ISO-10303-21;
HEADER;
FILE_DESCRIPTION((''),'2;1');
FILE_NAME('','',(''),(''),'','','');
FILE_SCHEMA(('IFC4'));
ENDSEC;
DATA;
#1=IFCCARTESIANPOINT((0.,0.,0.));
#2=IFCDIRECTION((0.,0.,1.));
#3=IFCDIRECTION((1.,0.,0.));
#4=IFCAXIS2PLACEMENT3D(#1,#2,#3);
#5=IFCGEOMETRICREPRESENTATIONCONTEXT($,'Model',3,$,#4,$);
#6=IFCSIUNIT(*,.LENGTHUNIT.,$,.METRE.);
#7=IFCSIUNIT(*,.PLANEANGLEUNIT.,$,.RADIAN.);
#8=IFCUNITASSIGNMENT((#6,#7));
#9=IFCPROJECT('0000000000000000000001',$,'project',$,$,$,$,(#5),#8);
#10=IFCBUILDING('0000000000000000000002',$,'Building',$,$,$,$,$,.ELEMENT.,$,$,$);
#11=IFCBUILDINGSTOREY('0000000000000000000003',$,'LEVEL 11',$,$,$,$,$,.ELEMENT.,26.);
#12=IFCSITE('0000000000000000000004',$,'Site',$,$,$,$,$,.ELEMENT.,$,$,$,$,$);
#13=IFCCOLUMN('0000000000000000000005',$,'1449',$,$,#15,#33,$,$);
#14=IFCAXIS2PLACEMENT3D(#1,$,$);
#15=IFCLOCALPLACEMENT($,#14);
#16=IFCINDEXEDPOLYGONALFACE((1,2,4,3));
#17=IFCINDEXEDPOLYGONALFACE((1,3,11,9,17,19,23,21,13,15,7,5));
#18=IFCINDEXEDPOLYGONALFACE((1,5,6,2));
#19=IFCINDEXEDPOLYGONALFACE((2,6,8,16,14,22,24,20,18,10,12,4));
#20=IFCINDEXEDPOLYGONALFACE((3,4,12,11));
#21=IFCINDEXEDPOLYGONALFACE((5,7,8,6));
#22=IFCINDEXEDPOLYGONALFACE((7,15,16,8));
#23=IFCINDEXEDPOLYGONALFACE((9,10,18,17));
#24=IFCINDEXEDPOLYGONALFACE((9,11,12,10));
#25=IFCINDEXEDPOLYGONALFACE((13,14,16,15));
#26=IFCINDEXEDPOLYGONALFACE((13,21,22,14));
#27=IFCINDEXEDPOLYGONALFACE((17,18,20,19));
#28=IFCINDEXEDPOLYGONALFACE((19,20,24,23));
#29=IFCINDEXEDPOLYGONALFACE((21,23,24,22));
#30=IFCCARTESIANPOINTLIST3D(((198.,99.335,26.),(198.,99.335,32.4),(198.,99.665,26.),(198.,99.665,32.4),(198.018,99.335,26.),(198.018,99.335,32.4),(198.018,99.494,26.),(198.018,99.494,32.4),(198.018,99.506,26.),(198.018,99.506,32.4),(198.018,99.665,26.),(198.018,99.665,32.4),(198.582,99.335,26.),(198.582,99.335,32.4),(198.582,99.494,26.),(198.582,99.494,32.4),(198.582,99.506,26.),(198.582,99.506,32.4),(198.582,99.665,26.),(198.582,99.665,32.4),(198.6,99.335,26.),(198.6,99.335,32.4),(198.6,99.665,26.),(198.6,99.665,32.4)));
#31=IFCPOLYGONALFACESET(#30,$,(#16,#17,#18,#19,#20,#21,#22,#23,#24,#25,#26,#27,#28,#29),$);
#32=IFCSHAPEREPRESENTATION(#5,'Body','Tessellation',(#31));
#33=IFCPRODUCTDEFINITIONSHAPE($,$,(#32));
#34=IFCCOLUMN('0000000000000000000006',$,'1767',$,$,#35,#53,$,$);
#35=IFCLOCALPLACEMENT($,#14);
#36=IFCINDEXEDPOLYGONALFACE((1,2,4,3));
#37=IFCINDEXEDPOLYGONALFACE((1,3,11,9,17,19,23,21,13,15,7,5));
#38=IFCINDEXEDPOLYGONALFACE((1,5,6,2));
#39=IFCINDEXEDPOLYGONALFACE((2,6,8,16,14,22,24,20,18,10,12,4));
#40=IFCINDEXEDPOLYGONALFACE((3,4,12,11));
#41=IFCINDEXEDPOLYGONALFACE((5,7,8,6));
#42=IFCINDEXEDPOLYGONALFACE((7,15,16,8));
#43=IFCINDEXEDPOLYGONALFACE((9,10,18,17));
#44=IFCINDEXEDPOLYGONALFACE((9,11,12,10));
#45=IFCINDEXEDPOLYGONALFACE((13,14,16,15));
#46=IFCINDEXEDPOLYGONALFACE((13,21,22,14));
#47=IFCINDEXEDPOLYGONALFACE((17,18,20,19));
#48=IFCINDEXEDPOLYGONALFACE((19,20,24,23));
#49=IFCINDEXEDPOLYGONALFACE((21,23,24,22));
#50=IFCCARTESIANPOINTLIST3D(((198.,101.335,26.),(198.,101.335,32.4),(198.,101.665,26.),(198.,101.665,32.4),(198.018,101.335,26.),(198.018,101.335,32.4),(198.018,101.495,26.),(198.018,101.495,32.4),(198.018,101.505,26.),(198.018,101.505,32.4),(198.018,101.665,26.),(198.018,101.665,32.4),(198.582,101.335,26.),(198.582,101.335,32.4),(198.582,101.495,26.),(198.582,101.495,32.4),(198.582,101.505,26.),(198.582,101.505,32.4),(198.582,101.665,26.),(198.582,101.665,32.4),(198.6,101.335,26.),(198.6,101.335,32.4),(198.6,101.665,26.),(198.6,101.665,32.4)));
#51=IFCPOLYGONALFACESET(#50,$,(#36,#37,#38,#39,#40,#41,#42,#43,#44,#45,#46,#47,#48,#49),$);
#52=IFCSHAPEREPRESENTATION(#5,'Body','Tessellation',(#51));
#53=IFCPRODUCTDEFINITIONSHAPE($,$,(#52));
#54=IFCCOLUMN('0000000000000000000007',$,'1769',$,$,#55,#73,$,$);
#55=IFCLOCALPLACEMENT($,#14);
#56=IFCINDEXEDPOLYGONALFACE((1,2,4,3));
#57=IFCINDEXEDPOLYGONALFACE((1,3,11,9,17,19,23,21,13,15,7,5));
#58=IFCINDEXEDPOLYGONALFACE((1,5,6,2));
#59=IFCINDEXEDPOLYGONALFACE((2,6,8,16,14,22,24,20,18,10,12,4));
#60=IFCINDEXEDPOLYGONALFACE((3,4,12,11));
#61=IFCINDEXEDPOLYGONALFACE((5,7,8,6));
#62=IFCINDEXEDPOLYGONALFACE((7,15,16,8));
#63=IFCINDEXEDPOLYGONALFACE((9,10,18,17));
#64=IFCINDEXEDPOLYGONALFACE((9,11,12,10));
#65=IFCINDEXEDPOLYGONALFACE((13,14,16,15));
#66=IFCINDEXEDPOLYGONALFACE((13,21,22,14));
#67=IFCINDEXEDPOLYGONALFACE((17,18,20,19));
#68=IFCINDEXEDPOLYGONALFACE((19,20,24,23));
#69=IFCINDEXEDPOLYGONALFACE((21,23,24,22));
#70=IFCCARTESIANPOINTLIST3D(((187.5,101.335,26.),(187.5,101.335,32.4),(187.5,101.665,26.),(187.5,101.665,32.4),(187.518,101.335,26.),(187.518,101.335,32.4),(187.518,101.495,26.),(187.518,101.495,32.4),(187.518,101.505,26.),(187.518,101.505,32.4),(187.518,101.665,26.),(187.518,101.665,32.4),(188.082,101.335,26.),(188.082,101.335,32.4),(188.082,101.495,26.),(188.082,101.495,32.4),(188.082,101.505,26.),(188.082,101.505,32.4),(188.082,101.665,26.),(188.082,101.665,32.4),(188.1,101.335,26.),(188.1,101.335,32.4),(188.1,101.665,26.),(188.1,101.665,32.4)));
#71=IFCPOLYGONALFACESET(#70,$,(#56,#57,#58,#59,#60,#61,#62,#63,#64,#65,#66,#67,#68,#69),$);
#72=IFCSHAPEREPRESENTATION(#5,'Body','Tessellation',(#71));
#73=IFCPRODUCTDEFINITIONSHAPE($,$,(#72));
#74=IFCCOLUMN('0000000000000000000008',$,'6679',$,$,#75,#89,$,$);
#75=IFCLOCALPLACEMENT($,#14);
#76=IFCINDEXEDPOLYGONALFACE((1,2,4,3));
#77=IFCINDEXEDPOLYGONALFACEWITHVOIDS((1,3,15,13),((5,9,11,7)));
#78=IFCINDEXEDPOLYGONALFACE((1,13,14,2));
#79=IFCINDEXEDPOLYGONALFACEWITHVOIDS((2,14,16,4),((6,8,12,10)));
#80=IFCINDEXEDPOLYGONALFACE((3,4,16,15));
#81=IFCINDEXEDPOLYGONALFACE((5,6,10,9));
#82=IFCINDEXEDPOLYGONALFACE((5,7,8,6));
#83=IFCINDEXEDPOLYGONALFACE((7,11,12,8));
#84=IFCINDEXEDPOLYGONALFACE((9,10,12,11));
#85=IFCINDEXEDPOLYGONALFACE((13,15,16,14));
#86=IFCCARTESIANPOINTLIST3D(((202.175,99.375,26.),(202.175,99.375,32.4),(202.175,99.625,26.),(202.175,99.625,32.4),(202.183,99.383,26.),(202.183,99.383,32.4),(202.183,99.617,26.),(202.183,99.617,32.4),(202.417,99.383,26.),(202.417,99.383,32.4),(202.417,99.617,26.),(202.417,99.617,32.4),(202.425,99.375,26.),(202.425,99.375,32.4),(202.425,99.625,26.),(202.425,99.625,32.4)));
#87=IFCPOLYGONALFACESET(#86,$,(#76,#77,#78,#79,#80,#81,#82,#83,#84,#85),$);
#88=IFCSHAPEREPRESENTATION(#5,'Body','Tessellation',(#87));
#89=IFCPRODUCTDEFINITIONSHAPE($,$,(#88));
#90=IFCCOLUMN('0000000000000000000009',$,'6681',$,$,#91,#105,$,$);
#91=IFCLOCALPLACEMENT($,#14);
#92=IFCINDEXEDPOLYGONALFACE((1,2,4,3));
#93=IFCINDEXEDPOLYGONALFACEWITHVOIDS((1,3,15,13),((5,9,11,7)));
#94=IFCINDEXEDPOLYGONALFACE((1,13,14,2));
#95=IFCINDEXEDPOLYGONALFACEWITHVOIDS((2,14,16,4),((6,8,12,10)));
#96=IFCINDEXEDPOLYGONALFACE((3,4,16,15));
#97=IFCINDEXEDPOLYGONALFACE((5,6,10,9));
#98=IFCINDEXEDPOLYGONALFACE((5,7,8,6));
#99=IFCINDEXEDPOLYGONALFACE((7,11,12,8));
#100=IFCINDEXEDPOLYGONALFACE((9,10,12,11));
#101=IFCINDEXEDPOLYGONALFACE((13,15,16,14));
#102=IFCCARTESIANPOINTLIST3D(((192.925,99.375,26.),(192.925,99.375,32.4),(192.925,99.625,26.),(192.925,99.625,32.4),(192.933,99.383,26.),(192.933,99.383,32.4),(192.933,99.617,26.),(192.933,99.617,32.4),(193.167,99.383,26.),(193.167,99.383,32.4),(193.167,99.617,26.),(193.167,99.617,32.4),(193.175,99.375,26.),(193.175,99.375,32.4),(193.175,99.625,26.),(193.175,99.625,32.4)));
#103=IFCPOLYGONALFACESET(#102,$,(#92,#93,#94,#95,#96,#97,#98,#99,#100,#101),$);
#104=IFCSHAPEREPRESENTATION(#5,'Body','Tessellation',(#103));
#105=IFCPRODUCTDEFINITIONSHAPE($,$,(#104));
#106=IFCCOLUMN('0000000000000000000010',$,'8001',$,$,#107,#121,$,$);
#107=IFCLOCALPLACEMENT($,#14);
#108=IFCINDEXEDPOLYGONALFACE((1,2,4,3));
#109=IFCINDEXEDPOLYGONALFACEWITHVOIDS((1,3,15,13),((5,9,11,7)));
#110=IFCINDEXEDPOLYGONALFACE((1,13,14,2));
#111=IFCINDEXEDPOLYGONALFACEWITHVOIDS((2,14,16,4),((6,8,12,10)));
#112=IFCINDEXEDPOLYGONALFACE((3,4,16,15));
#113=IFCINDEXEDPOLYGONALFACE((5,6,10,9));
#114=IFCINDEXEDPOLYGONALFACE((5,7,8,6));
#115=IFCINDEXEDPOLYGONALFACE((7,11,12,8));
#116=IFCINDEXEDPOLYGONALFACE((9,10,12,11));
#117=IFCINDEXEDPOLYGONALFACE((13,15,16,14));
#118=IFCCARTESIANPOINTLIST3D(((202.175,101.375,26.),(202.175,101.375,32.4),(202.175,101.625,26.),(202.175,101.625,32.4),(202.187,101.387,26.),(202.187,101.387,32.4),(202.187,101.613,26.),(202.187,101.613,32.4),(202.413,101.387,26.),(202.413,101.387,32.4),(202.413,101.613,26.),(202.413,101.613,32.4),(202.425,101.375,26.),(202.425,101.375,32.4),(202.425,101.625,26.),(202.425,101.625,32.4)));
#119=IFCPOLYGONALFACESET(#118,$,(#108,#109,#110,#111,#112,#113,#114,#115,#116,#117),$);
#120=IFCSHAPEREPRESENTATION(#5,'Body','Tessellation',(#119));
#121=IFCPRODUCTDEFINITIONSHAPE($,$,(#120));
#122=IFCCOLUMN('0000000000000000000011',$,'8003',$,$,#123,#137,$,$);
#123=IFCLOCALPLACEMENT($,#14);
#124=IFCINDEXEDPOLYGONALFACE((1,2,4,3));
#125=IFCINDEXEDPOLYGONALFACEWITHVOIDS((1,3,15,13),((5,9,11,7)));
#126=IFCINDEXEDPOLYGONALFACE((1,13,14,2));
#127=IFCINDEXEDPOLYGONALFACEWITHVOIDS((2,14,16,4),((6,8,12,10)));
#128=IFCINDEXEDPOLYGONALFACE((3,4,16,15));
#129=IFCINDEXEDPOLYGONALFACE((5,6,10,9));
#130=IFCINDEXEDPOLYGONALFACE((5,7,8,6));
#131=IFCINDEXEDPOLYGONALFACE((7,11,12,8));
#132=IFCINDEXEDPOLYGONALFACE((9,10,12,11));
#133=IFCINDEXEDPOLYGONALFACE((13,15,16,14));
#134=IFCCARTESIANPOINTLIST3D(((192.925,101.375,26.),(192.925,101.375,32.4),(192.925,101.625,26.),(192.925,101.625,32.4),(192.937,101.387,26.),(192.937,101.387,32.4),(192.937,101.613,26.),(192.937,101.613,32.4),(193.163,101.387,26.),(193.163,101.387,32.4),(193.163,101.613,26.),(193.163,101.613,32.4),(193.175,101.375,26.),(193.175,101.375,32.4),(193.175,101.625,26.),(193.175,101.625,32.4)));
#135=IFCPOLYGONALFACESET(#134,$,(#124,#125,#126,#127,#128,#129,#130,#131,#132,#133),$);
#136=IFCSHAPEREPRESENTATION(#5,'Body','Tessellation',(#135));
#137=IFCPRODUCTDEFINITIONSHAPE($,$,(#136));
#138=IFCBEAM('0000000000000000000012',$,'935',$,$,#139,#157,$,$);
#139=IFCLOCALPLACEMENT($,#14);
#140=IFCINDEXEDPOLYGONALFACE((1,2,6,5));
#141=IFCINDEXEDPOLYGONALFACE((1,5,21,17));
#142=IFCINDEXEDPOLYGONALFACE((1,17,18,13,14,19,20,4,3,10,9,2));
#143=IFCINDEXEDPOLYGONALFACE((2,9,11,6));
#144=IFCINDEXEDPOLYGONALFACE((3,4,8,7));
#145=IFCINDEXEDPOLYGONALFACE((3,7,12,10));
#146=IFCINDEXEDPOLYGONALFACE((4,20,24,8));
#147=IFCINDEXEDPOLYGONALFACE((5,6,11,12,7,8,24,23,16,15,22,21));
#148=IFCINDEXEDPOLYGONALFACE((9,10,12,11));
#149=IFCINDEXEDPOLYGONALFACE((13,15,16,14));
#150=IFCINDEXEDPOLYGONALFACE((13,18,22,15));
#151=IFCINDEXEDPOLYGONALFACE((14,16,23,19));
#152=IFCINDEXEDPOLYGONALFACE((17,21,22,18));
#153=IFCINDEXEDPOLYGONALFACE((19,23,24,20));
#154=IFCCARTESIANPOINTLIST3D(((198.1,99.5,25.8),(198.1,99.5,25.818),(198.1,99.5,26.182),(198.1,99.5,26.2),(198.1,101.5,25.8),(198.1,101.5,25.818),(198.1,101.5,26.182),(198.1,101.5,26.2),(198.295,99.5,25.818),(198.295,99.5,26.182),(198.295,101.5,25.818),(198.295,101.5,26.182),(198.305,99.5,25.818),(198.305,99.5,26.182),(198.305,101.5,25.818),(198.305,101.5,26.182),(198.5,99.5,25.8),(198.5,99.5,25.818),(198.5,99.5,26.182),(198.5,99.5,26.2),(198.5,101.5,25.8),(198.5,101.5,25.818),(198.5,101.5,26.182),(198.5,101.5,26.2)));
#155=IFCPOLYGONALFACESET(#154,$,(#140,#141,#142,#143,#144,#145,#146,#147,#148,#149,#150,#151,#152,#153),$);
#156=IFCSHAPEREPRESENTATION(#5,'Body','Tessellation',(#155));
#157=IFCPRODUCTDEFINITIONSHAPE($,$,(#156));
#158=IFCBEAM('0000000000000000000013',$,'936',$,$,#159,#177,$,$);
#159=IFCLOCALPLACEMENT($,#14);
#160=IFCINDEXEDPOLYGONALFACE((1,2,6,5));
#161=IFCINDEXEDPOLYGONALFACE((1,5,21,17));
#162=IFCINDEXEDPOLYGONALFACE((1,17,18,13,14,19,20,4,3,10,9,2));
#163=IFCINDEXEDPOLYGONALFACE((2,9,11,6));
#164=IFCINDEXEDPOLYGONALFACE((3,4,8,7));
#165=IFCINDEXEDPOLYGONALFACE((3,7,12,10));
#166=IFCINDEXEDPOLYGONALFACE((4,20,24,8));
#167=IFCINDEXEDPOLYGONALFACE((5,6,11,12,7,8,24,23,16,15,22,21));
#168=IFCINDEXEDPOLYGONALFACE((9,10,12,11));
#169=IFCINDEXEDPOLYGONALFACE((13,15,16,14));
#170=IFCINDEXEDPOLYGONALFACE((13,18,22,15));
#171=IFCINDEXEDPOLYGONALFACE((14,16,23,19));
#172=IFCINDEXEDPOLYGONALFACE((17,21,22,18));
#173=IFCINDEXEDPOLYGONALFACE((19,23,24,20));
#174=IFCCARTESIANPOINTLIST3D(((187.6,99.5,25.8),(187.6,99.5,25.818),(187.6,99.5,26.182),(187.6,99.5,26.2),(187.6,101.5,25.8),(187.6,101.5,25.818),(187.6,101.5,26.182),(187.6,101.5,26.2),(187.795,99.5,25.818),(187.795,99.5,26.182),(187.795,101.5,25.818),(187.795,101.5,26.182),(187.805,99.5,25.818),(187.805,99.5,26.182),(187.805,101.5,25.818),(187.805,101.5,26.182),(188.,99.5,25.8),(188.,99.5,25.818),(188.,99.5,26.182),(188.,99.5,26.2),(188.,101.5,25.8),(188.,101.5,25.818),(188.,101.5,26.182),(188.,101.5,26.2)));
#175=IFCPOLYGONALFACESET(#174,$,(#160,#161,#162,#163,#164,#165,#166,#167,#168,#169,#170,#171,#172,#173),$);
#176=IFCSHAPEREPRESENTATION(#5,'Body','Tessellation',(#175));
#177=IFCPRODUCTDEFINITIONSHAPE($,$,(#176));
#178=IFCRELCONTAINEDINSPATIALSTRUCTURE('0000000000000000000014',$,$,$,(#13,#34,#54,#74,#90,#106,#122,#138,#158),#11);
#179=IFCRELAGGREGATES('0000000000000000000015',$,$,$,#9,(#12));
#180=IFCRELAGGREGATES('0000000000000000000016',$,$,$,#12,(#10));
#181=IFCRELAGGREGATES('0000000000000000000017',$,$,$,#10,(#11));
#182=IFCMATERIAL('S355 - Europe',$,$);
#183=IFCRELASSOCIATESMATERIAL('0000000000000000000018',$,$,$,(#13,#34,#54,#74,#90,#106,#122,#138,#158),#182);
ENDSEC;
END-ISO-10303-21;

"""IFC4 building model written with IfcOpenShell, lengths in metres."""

from ifc_helpers import new_model, si_unit, frame, origin_with_axes, origin_2d_with_axis, place, context, project, spatial, hollow_rectangle, i_section, extrude, material, material_profile, profile_set, profile_usage, element, save


model = new_model("IFC4")

# Units and contexts
model_context = context("Model", 3, world=origin_with_axes())
ifc_project = project(units=[si_unit("LENGTHUNIT", "METRE"), si_unit("PLANEANGLEUNIT", "RADIAN")], contexts=[model_context])

# Site, building, storey
site = spatial("IfcSite", under=ifc_project, Name="Site", CompositionType="ELEMENT")
building = spatial("IfcBuilding", under=site, Name="Building", CompositionType="ELEMENT")
storey = spatial("IfcBuildingStorey", under=building, Name="LEVEL 11", CompositionType="ELEMENT", Elevation=26.0)

# Columns
ifc_material = material(Name="S355 - Europe")
ifc_material_profile_1 = material_profile(ifc_material, i_section(OverallWidth=0.33, OverallDepth=0.6, WebThickness=0.012, FlangeThickness=0.018, at=origin_2d_with_axis()))
ifc_profile_set_1 = profile_set([ifc_material_profile_1])
ifc_profile_usage_1 = profile_usage(ifc_profile_set_1, cardinal=10)
column_1_placement = place(None, frame((198.3, 99.5, 26.0), z_axis=(0.0, 0.0, 1.0), x_axis=(0.0, -1.0, 0.0)))
element("IfcColumn", 1, at=column_1_placement, inside=storey, material=ifc_profile_usage_1, Name="1449", context=model_context, shape_type="SweptSolid", body=[
    extrude(i_section(OverallWidth=0.33, OverallDepth=0.6, WebThickness=0.012, FlangeThickness=0.018, at=origin_2d_with_axis()), origin_with_axes(), (0.0, 0.0, 1.0), 6.4),
])
ifc_material_profile_2 = material_profile(ifc_material, i_section(OverallWidth=0.33, OverallDepth=0.6, WebThickness=0.01, FlangeThickness=0.018, at=origin_2d_with_axis()))
ifc_profile_set_2 = profile_set([ifc_material_profile_2])
ifc_profile_usage_2 = profile_usage(ifc_profile_set_2, cardinal=10)
column_2_placement = place(None, frame((198.3, 101.5, 26.0), z_axis=(0.0, 0.0, 1.0), x_axis=(0.0, -1.0, 0.0)))
element("IfcColumn", 2, at=column_2_placement, inside=storey, material=ifc_profile_usage_2, Name="1767", context=model_context, shape_type="SweptSolid", body=[
    extrude(i_section(OverallWidth=0.33, OverallDepth=0.6, WebThickness=0.01, FlangeThickness=0.018, at=origin_2d_with_axis()), origin_with_axes(), (0.0, 0.0, 1.0), 6.4),
])
ifc_material_profile_3 = material_profile(ifc_material, i_section(OverallWidth=0.33, OverallDepth=0.6, WebThickness=0.01, FlangeThickness=0.018, at=origin_2d_with_axis()))
ifc_profile_set_3 = profile_set([ifc_material_profile_3])
ifc_profile_usage_3 = profile_usage(ifc_profile_set_3, cardinal=10)
column_3_placement = place(None, frame((187.8, 101.5, 26.0), z_axis=(0.0, 0.0, 1.0), x_axis=(0.0, -1.0, 0.0)))
element("IfcColumn", 3, at=column_3_placement, inside=storey, material=ifc_profile_usage_3, Name="1769", context=model_context, shape_type="SweptSolid", body=[
    extrude(i_section(OverallWidth=0.33, OverallDepth=0.6, WebThickness=0.01, FlangeThickness=0.018, at=origin_2d_with_axis()), origin_with_axes(), (0.0, 0.0, 1.0), 6.4),
])
ifc_material_profile_4 = material_profile(ifc_material, hollow_rectangle(XDim=0.25, YDim=0.25, WallThickness=0.008, at=origin_2d_with_axis()))
ifc_profile_set_4 = profile_set([ifc_material_profile_4])
ifc_profile_usage_4 = profile_usage(ifc_profile_set_4, cardinal=10)
column_4_placement = place(None, frame((202.3, 99.5, 26.0), z_axis=(0.0, 0.0, 1.0), x_axis=(0.0, -1.0, 0.0)))
element("IfcColumn", 4, at=column_4_placement, inside=storey, material=ifc_profile_usage_4, Name="6679", context=model_context, shape_type="SweptSolid", body=[
    extrude(hollow_rectangle(XDim=0.25, YDim=0.25, WallThickness=0.008, at=origin_2d_with_axis()), origin_with_axes(), (0.0, 0.0, 1.0), 6.4),
])
ifc_material_profile_5 = material_profile(ifc_material, hollow_rectangle(XDim=0.25, YDim=0.25, WallThickness=0.008, at=origin_2d_with_axis()))
ifc_profile_set_5 = profile_set([ifc_material_profile_5])
ifc_profile_usage_5 = profile_usage(ifc_profile_set_5, cardinal=10)
column_5_placement = place(None, frame((193.05, 99.5, 26.0), z_axis=(0.0, 0.0, 1.0), x_axis=(0.0, -1.0, 0.0)))
element("IfcColumn", 5, at=column_5_placement, inside=storey, material=ifc_profile_usage_5, Name="6681", context=model_context, shape_type="SweptSolid", body=[
    extrude(hollow_rectangle(XDim=0.25, YDim=0.25, WallThickness=0.008, at=origin_2d_with_axis()), origin_with_axes(), (0.0, 0.0, 1.0), 6.4),
])
ifc_material_profile_6 = material_profile(ifc_material, hollow_rectangle(XDim=0.25, YDim=0.25, WallThickness=0.012, at=origin_2d_with_axis()))
ifc_profile_set_6 = profile_set([ifc_material_profile_6])
ifc_profile_usage_6 = profile_usage(ifc_profile_set_6, cardinal=10)
column_6_placement = place(None, frame((202.3, 101.5, 26.0), z_axis=(0.0, 0.0, 1.0), x_axis=(0.0, -1.0, 0.0)))
element("IfcColumn", 6, at=column_6_placement, inside=storey, material=ifc_profile_usage_6, Name="8001", context=model_context, shape_type="SweptSolid", body=[
    extrude(hollow_rectangle(XDim=0.25, YDim=0.25, WallThickness=0.012, at=origin_2d_with_axis()), origin_with_axes(), (0.0, 0.0, 1.0), 6.4),
])
ifc_material_profile_7 = material_profile(ifc_material, hollow_rectangle(XDim=0.25, YDim=0.25, WallThickness=0.012, at=origin_2d_with_axis()))
ifc_profile_set_7 = profile_set([ifc_material_profile_7])
ifc_profile_usage_7 = profile_usage(ifc_profile_set_7, cardinal=10)
column_7_placement = place(None, frame((193.05, 101.5, 26.0), z_axis=(0.0, 0.0, 1.0), x_axis=(0.0, -1.0, 0.0)))
element("IfcColumn", 7, at=column_7_placement, inside=storey, material=ifc_profile_usage_7, Name="8003", context=model_context, shape_type="SweptSolid", body=[
    extrude(hollow_rectangle(XDim=0.25, YDim=0.25, WallThickness=0.012, at=origin_2d_with_axis()), origin_with_axes(), (0.0, 0.0, 1.0), 6.4),
])

# Beams
ifc_material_profile_8 = material_profile(ifc_material, i_section(OverallWidth=0.4, OverallDepth=0.4, WebThickness=0.01, FlangeThickness=0.018, at=origin_2d_with_axis()))
ifc_profile_set_8 = profile_set([ifc_material_profile_8])
ifc_profile_usage_8 = profile_usage(ifc_profile_set_8, cardinal=10)
beam_1_placement = place(None, frame((198.3, 101.5, 26.0), z_axis=(0.0, -1.0, 0.0), x_axis=(1.0, 0.0, 0.0)))
element("IfcBeam", 8, at=beam_1_placement, inside=storey, material=ifc_profile_usage_8, Name="935", context=model_context, shape_type="SweptSolid", body=[
    extrude(i_section(OverallWidth=0.4, OverallDepth=0.4, WebThickness=0.01, FlangeThickness=0.018, at=origin_2d_with_axis()), origin_with_axes(), (0.0, 0.0, 1.0), 2.0),
])
ifc_material_profile_9 = material_profile(ifc_material, i_section(OverallWidth=0.4, OverallDepth=0.4, WebThickness=0.01, FlangeThickness=0.018, at=origin_2d_with_axis()))
ifc_profile_set_9 = profile_set([ifc_material_profile_9])
ifc_profile_usage_9 = profile_usage(ifc_profile_set_9, cardinal=10)
beam_2_placement = place(None, frame((187.8, 101.5, 26.0), z_axis=(0.0, -1.0, 0.0), x_axis=(1.0, 0.0, 0.0)))
element("IfcBeam", 9, at=beam_2_placement, inside=storey, material=ifc_profile_usage_9, Name="936", context=model_context, shape_type="SweptSolid", body=[
    extrude(i_section(OverallWidth=0.4, OverallDepth=0.4, WebThickness=0.01, FlangeThickness=0.018, at=origin_2d_with_axis()), origin_with_axes(), (0.0, 0.0, 1.0), 2.0),
])

save(model, "model.ifc")
